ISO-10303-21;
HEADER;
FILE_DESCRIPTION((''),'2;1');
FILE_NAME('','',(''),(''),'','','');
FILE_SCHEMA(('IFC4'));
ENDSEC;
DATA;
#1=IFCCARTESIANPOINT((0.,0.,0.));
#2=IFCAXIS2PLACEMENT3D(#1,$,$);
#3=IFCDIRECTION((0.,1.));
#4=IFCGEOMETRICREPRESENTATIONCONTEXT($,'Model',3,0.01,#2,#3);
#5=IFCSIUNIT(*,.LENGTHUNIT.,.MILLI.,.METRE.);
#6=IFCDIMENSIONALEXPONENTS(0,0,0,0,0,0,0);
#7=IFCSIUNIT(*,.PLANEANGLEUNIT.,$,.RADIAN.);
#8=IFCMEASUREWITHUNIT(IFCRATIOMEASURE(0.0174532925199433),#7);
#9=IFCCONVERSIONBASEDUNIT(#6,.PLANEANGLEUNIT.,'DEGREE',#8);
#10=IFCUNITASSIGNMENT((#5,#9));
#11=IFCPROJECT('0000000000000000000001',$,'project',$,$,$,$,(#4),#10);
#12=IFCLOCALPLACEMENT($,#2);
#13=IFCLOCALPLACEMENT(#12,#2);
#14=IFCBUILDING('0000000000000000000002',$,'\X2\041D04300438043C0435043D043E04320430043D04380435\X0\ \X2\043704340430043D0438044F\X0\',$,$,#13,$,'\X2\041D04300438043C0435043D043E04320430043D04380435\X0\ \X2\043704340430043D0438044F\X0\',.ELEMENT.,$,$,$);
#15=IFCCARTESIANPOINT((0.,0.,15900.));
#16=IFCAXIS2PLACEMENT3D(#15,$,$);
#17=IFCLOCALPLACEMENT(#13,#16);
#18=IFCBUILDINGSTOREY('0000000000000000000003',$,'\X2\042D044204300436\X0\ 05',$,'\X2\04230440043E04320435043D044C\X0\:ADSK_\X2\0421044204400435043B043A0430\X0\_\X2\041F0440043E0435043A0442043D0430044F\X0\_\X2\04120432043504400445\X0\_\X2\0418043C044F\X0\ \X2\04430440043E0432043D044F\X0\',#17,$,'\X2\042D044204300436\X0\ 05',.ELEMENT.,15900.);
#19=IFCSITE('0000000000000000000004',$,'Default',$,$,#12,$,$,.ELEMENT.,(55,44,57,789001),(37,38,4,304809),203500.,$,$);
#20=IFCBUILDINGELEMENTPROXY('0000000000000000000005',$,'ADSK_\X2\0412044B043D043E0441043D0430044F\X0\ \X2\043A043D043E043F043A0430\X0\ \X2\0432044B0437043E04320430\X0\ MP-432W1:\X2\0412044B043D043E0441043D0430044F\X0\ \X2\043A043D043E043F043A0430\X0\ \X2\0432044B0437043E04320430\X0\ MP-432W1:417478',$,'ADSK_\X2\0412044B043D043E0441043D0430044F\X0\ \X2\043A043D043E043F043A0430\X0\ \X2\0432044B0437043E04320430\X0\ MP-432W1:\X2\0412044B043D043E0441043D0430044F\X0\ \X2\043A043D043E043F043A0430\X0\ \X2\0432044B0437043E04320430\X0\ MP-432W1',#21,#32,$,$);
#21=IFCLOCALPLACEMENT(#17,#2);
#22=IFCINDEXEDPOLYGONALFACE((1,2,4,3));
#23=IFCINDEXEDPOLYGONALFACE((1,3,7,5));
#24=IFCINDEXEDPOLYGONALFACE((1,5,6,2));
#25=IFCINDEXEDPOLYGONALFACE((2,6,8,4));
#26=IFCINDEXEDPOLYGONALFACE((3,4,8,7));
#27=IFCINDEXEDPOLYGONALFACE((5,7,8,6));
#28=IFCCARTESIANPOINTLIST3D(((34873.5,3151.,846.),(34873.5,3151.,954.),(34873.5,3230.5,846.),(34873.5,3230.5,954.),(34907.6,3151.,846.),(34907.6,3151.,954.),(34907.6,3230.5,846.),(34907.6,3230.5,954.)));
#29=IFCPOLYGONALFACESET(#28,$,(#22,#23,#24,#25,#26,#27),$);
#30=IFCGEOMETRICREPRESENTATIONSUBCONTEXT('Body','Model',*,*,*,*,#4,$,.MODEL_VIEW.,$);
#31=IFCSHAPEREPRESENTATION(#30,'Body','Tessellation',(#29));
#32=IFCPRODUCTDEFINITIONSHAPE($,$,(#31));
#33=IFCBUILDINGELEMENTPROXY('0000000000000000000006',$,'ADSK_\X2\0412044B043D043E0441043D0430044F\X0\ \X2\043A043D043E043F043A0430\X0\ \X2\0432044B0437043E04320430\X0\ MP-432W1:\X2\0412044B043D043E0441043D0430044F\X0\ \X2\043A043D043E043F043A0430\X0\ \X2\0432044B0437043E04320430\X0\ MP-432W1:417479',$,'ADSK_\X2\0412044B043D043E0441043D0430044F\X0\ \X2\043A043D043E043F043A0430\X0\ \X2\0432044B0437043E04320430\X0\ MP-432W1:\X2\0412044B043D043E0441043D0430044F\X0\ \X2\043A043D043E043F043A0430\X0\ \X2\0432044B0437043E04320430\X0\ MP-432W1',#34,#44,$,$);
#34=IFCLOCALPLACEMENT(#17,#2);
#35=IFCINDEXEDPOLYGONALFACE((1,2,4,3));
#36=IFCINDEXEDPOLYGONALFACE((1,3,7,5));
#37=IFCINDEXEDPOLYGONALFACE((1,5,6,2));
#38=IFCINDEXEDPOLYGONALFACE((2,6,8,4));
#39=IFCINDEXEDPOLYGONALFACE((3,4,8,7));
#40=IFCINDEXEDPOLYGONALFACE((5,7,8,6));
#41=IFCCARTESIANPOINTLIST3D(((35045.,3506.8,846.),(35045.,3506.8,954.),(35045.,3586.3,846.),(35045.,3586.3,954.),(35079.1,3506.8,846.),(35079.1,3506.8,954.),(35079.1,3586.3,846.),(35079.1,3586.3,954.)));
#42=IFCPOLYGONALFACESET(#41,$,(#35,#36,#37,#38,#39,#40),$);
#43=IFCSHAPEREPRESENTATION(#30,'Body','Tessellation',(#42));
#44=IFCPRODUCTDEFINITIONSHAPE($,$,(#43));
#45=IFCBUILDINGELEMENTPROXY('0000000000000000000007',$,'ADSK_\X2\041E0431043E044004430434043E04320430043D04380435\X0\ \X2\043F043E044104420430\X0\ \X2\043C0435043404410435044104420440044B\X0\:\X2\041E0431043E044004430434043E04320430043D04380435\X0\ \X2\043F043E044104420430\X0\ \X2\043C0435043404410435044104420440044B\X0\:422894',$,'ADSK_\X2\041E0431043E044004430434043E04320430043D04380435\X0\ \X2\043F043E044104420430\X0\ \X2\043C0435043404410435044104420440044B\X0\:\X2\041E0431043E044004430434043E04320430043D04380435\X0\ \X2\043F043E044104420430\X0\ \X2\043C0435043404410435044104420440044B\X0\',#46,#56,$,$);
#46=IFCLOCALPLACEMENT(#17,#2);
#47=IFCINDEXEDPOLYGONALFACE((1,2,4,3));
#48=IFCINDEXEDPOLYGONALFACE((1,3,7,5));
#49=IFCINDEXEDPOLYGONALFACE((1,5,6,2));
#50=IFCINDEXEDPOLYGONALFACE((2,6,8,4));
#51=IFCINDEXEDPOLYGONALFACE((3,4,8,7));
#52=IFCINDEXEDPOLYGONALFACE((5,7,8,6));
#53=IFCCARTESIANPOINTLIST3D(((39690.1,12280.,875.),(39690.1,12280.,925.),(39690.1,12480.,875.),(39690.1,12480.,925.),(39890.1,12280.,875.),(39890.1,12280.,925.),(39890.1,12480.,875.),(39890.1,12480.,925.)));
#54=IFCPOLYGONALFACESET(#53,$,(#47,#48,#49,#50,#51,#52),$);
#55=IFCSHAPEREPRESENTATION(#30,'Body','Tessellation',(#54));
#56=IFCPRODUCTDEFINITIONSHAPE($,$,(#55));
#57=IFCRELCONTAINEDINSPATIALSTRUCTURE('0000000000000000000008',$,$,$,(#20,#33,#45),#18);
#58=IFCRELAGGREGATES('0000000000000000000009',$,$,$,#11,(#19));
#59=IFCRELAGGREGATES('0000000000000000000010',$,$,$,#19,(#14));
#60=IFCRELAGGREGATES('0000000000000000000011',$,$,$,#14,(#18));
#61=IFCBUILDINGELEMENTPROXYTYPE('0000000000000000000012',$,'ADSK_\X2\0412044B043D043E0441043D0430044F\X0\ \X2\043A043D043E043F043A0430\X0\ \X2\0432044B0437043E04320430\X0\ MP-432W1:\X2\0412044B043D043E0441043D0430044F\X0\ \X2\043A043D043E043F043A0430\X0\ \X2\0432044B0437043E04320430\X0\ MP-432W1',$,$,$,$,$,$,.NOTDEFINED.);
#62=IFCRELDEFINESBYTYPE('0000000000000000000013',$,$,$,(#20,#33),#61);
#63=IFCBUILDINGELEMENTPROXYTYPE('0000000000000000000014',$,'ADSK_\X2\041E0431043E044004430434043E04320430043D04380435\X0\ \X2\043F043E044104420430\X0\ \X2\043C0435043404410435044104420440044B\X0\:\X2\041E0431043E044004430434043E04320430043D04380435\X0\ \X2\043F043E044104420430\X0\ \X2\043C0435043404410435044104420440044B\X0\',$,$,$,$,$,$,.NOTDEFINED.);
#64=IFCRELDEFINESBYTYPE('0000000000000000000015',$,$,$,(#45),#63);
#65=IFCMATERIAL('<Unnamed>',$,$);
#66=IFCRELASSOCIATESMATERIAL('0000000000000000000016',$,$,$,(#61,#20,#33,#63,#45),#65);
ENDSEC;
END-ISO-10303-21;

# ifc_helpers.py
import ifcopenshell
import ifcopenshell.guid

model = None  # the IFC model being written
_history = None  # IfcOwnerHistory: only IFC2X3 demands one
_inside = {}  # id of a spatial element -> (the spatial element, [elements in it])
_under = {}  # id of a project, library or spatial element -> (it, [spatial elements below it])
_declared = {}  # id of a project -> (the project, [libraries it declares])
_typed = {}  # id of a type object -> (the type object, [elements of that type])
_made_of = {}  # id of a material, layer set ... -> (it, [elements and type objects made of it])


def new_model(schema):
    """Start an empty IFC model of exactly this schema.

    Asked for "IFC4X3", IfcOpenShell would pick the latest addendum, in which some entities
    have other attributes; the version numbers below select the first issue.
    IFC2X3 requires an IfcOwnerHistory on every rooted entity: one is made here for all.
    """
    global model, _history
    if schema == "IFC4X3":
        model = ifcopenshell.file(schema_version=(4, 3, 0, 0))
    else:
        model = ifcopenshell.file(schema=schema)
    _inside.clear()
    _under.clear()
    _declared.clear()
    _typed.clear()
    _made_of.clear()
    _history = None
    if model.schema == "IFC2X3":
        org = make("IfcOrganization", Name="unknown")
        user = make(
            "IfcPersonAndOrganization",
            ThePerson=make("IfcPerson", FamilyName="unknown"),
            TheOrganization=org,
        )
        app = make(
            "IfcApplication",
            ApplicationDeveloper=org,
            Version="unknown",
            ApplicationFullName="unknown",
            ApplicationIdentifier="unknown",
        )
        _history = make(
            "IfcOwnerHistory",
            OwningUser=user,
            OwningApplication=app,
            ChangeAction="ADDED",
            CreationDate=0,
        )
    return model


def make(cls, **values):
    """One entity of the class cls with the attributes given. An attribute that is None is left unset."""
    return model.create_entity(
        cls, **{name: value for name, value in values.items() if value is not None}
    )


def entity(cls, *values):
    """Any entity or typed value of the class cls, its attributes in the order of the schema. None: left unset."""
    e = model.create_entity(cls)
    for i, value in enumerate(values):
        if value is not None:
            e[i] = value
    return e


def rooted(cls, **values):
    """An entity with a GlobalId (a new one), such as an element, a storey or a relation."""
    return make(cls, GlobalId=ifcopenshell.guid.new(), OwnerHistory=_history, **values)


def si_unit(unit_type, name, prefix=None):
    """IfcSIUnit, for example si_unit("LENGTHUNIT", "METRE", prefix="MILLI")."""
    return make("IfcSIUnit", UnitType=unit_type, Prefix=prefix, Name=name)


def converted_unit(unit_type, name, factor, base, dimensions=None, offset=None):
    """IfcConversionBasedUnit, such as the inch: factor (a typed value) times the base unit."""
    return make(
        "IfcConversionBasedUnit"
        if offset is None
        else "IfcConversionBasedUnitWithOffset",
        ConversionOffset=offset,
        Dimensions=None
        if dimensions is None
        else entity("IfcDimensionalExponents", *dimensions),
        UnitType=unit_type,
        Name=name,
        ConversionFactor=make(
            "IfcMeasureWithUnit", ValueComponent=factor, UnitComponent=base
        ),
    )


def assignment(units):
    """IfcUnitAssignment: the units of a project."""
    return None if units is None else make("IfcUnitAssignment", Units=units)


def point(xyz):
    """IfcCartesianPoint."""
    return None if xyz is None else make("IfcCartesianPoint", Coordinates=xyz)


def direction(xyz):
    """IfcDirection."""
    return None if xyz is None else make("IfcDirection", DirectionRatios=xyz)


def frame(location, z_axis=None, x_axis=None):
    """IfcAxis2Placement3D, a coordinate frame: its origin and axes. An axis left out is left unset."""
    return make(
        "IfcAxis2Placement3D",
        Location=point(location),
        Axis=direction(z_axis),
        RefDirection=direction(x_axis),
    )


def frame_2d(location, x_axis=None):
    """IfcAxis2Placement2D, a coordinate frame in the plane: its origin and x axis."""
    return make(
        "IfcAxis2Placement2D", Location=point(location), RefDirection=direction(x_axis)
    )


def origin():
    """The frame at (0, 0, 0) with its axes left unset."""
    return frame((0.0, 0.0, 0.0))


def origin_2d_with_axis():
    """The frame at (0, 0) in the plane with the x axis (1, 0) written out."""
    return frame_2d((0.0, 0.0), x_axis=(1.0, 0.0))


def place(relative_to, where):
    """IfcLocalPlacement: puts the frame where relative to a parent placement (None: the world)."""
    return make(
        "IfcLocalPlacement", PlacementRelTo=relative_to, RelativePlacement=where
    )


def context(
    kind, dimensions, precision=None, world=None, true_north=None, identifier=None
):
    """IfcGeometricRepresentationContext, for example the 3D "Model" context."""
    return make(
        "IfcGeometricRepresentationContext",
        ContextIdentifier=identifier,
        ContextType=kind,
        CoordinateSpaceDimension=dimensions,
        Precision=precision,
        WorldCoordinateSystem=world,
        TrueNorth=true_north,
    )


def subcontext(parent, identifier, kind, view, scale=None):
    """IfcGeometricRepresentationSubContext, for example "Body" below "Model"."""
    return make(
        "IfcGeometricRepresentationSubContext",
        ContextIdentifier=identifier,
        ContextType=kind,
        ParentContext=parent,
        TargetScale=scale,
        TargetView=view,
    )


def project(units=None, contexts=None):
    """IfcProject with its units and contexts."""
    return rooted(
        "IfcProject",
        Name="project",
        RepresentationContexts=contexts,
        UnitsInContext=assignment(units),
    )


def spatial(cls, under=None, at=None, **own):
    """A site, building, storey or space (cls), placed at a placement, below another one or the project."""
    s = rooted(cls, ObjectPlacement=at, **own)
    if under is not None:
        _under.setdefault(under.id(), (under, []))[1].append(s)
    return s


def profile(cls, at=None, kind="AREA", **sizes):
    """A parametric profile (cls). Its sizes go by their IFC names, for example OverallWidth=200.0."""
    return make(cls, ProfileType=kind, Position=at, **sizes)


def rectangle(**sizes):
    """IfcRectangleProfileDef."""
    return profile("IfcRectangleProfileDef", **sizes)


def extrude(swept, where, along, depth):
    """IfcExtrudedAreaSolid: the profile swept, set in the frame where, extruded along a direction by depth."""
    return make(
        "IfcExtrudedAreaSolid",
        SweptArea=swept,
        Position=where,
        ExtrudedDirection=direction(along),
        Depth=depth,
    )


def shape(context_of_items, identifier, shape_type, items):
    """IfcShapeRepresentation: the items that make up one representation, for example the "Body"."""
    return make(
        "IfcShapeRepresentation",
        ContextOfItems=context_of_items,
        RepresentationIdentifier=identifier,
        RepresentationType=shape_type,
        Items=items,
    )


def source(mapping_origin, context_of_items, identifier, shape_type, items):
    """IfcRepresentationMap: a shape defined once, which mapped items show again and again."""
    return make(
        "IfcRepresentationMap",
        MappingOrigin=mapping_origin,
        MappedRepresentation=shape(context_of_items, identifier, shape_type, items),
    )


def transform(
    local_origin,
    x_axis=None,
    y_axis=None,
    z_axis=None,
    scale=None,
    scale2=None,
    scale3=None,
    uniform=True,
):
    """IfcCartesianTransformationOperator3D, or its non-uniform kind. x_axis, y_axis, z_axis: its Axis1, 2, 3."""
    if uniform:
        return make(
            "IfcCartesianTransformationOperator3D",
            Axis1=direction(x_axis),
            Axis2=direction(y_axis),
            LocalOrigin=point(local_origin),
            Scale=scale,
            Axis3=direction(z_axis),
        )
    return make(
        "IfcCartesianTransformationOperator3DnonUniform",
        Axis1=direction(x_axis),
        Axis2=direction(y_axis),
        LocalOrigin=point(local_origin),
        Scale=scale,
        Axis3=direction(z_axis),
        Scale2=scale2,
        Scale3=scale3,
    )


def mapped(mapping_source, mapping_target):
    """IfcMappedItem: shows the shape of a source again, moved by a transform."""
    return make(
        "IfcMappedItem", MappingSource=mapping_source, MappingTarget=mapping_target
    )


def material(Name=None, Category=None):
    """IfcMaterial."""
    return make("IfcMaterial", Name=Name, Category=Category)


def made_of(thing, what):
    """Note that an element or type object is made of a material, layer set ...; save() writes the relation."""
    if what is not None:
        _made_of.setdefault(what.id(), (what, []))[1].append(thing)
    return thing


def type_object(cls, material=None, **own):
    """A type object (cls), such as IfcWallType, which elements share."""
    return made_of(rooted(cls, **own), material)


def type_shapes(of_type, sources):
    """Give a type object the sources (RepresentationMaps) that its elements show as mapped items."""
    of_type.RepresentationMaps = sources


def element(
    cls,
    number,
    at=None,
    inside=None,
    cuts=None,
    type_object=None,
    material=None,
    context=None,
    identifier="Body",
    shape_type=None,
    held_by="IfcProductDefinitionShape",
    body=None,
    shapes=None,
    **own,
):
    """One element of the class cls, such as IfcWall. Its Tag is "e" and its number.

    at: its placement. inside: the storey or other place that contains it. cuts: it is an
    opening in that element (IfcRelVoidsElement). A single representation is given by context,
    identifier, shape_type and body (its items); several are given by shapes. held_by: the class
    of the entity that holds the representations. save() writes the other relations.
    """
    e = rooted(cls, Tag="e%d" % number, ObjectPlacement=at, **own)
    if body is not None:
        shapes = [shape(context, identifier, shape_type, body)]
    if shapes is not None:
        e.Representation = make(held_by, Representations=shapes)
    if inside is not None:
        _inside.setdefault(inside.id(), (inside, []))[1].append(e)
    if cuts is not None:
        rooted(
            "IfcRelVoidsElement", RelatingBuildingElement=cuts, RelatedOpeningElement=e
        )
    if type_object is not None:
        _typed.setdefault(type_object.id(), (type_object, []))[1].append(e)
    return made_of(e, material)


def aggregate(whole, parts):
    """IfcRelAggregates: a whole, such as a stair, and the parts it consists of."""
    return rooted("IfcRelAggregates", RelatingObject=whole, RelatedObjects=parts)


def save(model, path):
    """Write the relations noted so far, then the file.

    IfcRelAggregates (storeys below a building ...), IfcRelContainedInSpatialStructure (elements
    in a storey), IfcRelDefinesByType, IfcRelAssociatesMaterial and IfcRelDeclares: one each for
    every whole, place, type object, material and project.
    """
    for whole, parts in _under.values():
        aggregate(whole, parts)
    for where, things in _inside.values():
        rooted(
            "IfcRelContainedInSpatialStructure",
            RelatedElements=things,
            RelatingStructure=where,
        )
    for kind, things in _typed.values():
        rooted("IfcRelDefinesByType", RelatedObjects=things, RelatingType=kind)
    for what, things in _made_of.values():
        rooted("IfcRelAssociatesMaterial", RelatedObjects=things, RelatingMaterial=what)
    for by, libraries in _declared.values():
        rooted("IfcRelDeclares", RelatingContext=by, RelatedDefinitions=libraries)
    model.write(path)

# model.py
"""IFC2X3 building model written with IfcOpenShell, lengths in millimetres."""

from ifc_helpers import new_model, entity, si_unit, converted_unit, direction, frame, origin, origin_2d_with_axis, place, context, subcontext, project, spatial, rectangle, extrude, source, transform, mapped, material, type_object, type_shapes, element, save


model = new_model("IFC2X3")

# Units and contexts
model_context = context("Model", 3, precision=0.01, world=origin(), true_north=direction((0.0, 1.0)))
body_context = subcontext(model_context, "Body", "Model", "MODEL_VIEW")
ifc_project = project(units=[si_unit("LENGTHUNIT", "METRE", prefix="MILLI"), converted_unit("PLANEANGLEUNIT", "DEGREE", entity("IfcRatioMeasure", 0.0174532925199433), si_unit("PLANEANGLEUNIT", "RADIAN"), dimensions=[0, 0, 0, 0, 0, 0, 0])], contexts=[model_context])

# Site, building, storey
site_placement = place(None, origin())
site = spatial("IfcSite", under=ifc_project, at=site_placement, Name="Default", CompositionType="ELEMENT", RefLatitude=(55, 44, 57, 789001), RefLongitude=(37, 38, 4, 304809), RefElevation=203500.0)
building_placement = place(site_placement, origin())
building = spatial("IfcBuilding", under=site, at=building_placement, Name="Наименование здания", LongName="Наименование здания", CompositionType="ELEMENT")
storey_placement = place(building_placement, frame((0.0, 0.0, 15900.0)))
storey = spatial("IfcBuildingStorey", under=building, at=storey_placement, Name="Этаж 05", ObjectType="Уровень:ADSK_Стрелка_Проектная_Вверх_Имя уровня", LongName="Этаж 05", CompositionType="ELEMENT", Elevation=15900.0)

# Building element proxies
ifc_material = material(Name="<Unnamed>")
building_element_proxy_type_1 = type_object("IfcBuildingElementProxyType", Name="ADSK_Выносная кнопка вызова MP-432W1:Выносная кнопка вызова MP-432W1", PredefinedType="NOTDEFINED", material=ifc_material)
shared_shape_1 = source(origin(), body_context, "Body", "SweptSolid", [
    extrude(rectangle(XDim=79.5, YDim=34.1, at=origin_2d_with_axis()), frame((0.0, 15.0, -54.0), z_axis=(0.0, 0.0, 1.0), x_axis=(-1.0, 0.0, 0.0)), (0.0, 0.0, 1.0), 108.0),
])
type_shapes(building_element_proxy_type_1, [shared_shape_1])
for number, where, z_axis, x_axis, name in (
    (1, (34875.6, 3190.8, 900.0), (0.0, 0.0, 1.0), (0.0, -1.0, 0.0), "ADSK_Выносная кнопка вызова MP-432W1:Выносная кнопка вызова MP-432W1:417478"),
    (2, (35077.0, 3546.5, 900.0), (0.0, 0.0, 1.0), (0.0, 1.0, 0.0), "ADSK_Выносная кнопка вызова MP-432W1:Выносная кнопка вызова MP-432W1:417479"),
):
    element("IfcBuildingElementProxy", number, at=place(storey_placement, frame(where, z_axis=z_axis, x_axis=x_axis)), inside=storey, type_object=building_element_proxy_type_1, material=ifc_material, Name=name, ObjectType="ADSK_Выносная кнопка вызова MP-432W1:Выносная кнопка вызова MP-432W1", context=body_context, shape_type="MappedRepresentation", body=[
        mapped(shared_shape_1, transform((0.0, 0.0, 0.0), scale=1.0)),
    ])
building_element_proxy_type_2 = type_object("IfcBuildingElementProxyType", Name="ADSK_Оборудование поста медсестры:Оборудование поста медсестры", PredefinedType="NOTDEFINED", material=ifc_material)
shared_shape_2 = source(origin(), body_context, "Body", "SweptSolid", [
    extrude(rectangle(XDim=200.0, YDim=200.0, at=origin_2d_with_axis()), frame((0.0, -68.0, -25.0), z_axis=(0.0, 0.0, 1.0), x_axis=(-1.0, 0.0, 0.0)), (0.0, 0.0, 1.0), 50.0),
])
type_shapes(building_element_proxy_type_2, [shared_shape_2])
proxy_1_placement = place(storey_placement, frame((39790.1, 12448.0, 900.0)))
element("IfcBuildingElementProxy", 3, at=proxy_1_placement, inside=storey, type_object=building_element_proxy_type_2, material=ifc_material, Name="ADSK_Оборудование поста медсестры:Оборудование поста медсестры:422894", ObjectType="ADSK_Оборудование поста медсестры:Оборудование поста медсестры", context=body_context, shape_type="MappedRepresentation", body=[
    mapped(shared_shape_2, transform((0.0, 0.0, 0.0), scale=1.0)),
])

save(model, "model.ifc")
